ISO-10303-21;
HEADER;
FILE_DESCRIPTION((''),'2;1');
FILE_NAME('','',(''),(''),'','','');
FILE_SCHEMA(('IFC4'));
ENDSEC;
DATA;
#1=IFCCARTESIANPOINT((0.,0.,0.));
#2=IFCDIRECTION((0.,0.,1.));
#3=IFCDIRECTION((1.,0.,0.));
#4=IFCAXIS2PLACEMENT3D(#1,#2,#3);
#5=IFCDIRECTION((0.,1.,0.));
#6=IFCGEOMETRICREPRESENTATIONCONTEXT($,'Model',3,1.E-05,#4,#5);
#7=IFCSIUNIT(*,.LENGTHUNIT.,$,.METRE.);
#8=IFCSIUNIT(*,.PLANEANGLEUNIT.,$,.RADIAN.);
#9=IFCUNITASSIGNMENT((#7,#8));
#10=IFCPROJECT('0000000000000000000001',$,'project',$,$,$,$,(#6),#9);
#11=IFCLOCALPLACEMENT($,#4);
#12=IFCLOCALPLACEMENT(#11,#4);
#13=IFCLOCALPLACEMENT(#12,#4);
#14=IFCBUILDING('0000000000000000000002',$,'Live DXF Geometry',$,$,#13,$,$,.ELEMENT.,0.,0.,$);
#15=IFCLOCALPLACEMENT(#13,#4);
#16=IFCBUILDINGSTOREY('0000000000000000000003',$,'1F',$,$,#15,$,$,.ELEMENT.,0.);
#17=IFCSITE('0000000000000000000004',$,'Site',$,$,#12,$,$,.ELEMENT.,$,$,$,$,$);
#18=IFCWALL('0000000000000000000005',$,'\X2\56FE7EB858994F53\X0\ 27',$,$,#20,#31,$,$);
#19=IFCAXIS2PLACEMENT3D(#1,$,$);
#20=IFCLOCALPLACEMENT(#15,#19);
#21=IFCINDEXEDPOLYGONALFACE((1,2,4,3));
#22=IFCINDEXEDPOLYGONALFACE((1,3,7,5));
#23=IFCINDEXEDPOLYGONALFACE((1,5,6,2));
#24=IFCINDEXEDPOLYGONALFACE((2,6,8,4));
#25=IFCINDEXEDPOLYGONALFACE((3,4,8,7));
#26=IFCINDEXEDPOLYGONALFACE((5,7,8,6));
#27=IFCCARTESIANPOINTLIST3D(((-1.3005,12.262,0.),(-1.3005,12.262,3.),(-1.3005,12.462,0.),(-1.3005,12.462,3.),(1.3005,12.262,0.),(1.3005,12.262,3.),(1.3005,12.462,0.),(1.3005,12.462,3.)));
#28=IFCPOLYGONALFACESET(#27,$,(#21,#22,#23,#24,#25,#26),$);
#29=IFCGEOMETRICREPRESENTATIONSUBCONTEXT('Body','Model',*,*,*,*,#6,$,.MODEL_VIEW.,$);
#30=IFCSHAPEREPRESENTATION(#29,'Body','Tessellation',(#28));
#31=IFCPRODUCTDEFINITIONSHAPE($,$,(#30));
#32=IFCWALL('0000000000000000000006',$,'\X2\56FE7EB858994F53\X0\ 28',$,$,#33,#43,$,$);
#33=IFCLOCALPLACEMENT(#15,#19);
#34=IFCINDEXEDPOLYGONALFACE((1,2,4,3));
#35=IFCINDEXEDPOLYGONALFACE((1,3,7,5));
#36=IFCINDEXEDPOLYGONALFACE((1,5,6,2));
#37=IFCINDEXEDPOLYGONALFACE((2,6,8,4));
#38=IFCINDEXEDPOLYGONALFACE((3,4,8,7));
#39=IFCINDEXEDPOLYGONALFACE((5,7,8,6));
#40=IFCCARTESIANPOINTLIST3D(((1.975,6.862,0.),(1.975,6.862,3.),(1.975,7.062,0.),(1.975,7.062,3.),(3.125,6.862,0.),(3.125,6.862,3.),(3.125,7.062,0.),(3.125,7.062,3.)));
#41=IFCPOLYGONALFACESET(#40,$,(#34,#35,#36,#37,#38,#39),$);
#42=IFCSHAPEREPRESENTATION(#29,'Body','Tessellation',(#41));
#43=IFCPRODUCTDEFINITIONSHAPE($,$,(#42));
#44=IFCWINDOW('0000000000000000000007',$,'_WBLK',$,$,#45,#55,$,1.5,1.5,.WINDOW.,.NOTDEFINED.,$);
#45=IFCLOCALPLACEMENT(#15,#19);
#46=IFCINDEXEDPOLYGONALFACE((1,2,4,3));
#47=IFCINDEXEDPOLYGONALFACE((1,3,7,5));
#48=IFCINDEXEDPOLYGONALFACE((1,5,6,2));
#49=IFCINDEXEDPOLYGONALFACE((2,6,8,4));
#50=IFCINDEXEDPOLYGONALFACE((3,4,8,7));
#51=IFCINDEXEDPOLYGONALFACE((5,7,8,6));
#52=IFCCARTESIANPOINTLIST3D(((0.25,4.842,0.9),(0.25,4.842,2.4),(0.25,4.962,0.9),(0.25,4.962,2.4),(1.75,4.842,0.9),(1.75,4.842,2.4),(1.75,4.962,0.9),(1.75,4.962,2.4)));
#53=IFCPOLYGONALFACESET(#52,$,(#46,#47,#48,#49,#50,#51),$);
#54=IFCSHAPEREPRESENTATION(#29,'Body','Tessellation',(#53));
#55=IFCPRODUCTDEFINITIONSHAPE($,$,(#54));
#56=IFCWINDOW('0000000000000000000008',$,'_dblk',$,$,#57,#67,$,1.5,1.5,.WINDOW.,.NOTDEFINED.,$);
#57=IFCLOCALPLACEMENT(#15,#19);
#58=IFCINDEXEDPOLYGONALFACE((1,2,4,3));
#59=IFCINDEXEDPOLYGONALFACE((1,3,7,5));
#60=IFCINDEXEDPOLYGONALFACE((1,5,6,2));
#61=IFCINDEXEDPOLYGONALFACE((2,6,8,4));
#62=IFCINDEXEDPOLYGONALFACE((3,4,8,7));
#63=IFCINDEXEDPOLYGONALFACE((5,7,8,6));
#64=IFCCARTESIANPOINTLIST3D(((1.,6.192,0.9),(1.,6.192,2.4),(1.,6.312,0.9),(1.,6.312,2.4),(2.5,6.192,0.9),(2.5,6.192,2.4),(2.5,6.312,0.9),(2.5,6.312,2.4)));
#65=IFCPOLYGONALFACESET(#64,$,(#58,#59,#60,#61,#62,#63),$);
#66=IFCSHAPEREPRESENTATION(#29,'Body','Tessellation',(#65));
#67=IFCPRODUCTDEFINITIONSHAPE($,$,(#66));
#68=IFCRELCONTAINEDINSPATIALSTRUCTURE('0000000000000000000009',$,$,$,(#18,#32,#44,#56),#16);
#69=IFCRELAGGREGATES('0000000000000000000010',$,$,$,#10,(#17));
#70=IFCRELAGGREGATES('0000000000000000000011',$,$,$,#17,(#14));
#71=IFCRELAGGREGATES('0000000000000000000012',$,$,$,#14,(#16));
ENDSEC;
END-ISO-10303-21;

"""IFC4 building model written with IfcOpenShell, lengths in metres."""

from ifc_helpers import new_model, si_unit, direction, frame, frame_2d, origin_with_axes, place, context, subcontext, project, spatial, rectangle, extrude, element, save


model = new_model("IFC4")

# Units and contexts
model_context = context("Model", 3, precision=1e-05, world=origin_with_axes(), true_north=direction((0.0, 1.0, 0.0)))
body_context = subcontext(model_context, "Body", "Model", "MODEL_VIEW")
ifc_project = project(units=[si_unit("LENGTHUNIT", "METRE"), si_unit("PLANEANGLEUNIT", "RADIAN")], contexts=[model_context])

# Site, building, storey
placement = place(None, origin_with_axes())
site_placement = place(placement, origin_with_axes())
site = spatial("IfcSite", under=ifc_project, at=site_placement, Name="Site", CompositionType="ELEMENT")
building_placement = place(site_placement, origin_with_axes())
building = spatial("IfcBuilding", under=site, at=building_placement, Name="Live DXF Geometry", CompositionType="ELEMENT", ElevationOfRefHeight=0.0, ElevationOfTerrain=0.0)
storey_placement = place(building_placement, origin_with_axes())
storey = spatial("IfcBuildingStorey", under=building, at=storey_placement, Name="1F", CompositionType="ELEMENT", Elevation=0.0)

# Walls
wall_1_placement = place(storey_placement, frame((0.0, 12.362, 0.0), z_axis=(0.0, 0.0, 1.0), x_axis=(1.0, 0.0, 0.0)))
element("IfcWall", 1, at=wall_1_placement, inside=storey, Name="图纸墙体 27", context=body_context, shape_type="SweptSolid", body=[
    extrude(rectangle(XDim=2.601, YDim=0.2, at=frame_2d((0.0, 0.0), x_axis=(1.0, 0.0, 0.0))), frame((0.0, 0.0, 0.0), z_axis=(0.0, 0.0, 1.0)), (0.0, 0.0, 1.0), 3.0),
])
wall_2_placement = place(storey_placement, frame((2.55, 6.962, 0.0), z_axis=(0.0, 0.0, 1.0), x_axis=(-1.0, 0.0, 0.0)))
element("IfcWall", 2, at=wall_2_placement, inside=storey, Name="图纸墙体 28", context=body_context, shape_type="SweptSolid", body=[
    extrude(rectangle(XDim=1.15, YDim=0.2, at=frame_2d((0.0, 0.0), x_axis=(1.0, 0.0, 0.0))), frame((0.0, 0.0, 0.0), z_axis=(0.0, 0.0, 1.0)), (0.0, 0.0, 1.0), 3.0),
])

# Windows
for number, where, z_axis, x_axis, name in (
    (3, (1.0, 4.902, 0.9), (0.0, 0.0, 1.0), (1.0, 0.0, 0.0), "_WBLK"),
    (4, (1.75, 6.252, 0.9), (0.0, 0.0, 1.0), (1.0, 0.0, 0.0), "_dblk"),
):
    element("IfcWindow", number, at=place(storey_placement, frame(where, z_axis=z_axis, x_axis=x_axis)), inside=storey, Name=name, OverallHeight=1.5, OverallWidth=1.5, PartitioningType="NOTDEFINED", PredefinedType="WINDOW", context=body_context, shape_type="SweptSolid", body=[
        extrude(rectangle(XDim=1.5, YDim=0.12, at=frame_2d((0.0, 0.0), x_axis=(1.0, 0.0, 0.0))), frame((0.0, 0.0, 0.0), z_axis=(0.0, 0.0, 1.0)), (0.0, 0.0, 1.0), 1.5),
    ])

save(model, "model.ifc")
